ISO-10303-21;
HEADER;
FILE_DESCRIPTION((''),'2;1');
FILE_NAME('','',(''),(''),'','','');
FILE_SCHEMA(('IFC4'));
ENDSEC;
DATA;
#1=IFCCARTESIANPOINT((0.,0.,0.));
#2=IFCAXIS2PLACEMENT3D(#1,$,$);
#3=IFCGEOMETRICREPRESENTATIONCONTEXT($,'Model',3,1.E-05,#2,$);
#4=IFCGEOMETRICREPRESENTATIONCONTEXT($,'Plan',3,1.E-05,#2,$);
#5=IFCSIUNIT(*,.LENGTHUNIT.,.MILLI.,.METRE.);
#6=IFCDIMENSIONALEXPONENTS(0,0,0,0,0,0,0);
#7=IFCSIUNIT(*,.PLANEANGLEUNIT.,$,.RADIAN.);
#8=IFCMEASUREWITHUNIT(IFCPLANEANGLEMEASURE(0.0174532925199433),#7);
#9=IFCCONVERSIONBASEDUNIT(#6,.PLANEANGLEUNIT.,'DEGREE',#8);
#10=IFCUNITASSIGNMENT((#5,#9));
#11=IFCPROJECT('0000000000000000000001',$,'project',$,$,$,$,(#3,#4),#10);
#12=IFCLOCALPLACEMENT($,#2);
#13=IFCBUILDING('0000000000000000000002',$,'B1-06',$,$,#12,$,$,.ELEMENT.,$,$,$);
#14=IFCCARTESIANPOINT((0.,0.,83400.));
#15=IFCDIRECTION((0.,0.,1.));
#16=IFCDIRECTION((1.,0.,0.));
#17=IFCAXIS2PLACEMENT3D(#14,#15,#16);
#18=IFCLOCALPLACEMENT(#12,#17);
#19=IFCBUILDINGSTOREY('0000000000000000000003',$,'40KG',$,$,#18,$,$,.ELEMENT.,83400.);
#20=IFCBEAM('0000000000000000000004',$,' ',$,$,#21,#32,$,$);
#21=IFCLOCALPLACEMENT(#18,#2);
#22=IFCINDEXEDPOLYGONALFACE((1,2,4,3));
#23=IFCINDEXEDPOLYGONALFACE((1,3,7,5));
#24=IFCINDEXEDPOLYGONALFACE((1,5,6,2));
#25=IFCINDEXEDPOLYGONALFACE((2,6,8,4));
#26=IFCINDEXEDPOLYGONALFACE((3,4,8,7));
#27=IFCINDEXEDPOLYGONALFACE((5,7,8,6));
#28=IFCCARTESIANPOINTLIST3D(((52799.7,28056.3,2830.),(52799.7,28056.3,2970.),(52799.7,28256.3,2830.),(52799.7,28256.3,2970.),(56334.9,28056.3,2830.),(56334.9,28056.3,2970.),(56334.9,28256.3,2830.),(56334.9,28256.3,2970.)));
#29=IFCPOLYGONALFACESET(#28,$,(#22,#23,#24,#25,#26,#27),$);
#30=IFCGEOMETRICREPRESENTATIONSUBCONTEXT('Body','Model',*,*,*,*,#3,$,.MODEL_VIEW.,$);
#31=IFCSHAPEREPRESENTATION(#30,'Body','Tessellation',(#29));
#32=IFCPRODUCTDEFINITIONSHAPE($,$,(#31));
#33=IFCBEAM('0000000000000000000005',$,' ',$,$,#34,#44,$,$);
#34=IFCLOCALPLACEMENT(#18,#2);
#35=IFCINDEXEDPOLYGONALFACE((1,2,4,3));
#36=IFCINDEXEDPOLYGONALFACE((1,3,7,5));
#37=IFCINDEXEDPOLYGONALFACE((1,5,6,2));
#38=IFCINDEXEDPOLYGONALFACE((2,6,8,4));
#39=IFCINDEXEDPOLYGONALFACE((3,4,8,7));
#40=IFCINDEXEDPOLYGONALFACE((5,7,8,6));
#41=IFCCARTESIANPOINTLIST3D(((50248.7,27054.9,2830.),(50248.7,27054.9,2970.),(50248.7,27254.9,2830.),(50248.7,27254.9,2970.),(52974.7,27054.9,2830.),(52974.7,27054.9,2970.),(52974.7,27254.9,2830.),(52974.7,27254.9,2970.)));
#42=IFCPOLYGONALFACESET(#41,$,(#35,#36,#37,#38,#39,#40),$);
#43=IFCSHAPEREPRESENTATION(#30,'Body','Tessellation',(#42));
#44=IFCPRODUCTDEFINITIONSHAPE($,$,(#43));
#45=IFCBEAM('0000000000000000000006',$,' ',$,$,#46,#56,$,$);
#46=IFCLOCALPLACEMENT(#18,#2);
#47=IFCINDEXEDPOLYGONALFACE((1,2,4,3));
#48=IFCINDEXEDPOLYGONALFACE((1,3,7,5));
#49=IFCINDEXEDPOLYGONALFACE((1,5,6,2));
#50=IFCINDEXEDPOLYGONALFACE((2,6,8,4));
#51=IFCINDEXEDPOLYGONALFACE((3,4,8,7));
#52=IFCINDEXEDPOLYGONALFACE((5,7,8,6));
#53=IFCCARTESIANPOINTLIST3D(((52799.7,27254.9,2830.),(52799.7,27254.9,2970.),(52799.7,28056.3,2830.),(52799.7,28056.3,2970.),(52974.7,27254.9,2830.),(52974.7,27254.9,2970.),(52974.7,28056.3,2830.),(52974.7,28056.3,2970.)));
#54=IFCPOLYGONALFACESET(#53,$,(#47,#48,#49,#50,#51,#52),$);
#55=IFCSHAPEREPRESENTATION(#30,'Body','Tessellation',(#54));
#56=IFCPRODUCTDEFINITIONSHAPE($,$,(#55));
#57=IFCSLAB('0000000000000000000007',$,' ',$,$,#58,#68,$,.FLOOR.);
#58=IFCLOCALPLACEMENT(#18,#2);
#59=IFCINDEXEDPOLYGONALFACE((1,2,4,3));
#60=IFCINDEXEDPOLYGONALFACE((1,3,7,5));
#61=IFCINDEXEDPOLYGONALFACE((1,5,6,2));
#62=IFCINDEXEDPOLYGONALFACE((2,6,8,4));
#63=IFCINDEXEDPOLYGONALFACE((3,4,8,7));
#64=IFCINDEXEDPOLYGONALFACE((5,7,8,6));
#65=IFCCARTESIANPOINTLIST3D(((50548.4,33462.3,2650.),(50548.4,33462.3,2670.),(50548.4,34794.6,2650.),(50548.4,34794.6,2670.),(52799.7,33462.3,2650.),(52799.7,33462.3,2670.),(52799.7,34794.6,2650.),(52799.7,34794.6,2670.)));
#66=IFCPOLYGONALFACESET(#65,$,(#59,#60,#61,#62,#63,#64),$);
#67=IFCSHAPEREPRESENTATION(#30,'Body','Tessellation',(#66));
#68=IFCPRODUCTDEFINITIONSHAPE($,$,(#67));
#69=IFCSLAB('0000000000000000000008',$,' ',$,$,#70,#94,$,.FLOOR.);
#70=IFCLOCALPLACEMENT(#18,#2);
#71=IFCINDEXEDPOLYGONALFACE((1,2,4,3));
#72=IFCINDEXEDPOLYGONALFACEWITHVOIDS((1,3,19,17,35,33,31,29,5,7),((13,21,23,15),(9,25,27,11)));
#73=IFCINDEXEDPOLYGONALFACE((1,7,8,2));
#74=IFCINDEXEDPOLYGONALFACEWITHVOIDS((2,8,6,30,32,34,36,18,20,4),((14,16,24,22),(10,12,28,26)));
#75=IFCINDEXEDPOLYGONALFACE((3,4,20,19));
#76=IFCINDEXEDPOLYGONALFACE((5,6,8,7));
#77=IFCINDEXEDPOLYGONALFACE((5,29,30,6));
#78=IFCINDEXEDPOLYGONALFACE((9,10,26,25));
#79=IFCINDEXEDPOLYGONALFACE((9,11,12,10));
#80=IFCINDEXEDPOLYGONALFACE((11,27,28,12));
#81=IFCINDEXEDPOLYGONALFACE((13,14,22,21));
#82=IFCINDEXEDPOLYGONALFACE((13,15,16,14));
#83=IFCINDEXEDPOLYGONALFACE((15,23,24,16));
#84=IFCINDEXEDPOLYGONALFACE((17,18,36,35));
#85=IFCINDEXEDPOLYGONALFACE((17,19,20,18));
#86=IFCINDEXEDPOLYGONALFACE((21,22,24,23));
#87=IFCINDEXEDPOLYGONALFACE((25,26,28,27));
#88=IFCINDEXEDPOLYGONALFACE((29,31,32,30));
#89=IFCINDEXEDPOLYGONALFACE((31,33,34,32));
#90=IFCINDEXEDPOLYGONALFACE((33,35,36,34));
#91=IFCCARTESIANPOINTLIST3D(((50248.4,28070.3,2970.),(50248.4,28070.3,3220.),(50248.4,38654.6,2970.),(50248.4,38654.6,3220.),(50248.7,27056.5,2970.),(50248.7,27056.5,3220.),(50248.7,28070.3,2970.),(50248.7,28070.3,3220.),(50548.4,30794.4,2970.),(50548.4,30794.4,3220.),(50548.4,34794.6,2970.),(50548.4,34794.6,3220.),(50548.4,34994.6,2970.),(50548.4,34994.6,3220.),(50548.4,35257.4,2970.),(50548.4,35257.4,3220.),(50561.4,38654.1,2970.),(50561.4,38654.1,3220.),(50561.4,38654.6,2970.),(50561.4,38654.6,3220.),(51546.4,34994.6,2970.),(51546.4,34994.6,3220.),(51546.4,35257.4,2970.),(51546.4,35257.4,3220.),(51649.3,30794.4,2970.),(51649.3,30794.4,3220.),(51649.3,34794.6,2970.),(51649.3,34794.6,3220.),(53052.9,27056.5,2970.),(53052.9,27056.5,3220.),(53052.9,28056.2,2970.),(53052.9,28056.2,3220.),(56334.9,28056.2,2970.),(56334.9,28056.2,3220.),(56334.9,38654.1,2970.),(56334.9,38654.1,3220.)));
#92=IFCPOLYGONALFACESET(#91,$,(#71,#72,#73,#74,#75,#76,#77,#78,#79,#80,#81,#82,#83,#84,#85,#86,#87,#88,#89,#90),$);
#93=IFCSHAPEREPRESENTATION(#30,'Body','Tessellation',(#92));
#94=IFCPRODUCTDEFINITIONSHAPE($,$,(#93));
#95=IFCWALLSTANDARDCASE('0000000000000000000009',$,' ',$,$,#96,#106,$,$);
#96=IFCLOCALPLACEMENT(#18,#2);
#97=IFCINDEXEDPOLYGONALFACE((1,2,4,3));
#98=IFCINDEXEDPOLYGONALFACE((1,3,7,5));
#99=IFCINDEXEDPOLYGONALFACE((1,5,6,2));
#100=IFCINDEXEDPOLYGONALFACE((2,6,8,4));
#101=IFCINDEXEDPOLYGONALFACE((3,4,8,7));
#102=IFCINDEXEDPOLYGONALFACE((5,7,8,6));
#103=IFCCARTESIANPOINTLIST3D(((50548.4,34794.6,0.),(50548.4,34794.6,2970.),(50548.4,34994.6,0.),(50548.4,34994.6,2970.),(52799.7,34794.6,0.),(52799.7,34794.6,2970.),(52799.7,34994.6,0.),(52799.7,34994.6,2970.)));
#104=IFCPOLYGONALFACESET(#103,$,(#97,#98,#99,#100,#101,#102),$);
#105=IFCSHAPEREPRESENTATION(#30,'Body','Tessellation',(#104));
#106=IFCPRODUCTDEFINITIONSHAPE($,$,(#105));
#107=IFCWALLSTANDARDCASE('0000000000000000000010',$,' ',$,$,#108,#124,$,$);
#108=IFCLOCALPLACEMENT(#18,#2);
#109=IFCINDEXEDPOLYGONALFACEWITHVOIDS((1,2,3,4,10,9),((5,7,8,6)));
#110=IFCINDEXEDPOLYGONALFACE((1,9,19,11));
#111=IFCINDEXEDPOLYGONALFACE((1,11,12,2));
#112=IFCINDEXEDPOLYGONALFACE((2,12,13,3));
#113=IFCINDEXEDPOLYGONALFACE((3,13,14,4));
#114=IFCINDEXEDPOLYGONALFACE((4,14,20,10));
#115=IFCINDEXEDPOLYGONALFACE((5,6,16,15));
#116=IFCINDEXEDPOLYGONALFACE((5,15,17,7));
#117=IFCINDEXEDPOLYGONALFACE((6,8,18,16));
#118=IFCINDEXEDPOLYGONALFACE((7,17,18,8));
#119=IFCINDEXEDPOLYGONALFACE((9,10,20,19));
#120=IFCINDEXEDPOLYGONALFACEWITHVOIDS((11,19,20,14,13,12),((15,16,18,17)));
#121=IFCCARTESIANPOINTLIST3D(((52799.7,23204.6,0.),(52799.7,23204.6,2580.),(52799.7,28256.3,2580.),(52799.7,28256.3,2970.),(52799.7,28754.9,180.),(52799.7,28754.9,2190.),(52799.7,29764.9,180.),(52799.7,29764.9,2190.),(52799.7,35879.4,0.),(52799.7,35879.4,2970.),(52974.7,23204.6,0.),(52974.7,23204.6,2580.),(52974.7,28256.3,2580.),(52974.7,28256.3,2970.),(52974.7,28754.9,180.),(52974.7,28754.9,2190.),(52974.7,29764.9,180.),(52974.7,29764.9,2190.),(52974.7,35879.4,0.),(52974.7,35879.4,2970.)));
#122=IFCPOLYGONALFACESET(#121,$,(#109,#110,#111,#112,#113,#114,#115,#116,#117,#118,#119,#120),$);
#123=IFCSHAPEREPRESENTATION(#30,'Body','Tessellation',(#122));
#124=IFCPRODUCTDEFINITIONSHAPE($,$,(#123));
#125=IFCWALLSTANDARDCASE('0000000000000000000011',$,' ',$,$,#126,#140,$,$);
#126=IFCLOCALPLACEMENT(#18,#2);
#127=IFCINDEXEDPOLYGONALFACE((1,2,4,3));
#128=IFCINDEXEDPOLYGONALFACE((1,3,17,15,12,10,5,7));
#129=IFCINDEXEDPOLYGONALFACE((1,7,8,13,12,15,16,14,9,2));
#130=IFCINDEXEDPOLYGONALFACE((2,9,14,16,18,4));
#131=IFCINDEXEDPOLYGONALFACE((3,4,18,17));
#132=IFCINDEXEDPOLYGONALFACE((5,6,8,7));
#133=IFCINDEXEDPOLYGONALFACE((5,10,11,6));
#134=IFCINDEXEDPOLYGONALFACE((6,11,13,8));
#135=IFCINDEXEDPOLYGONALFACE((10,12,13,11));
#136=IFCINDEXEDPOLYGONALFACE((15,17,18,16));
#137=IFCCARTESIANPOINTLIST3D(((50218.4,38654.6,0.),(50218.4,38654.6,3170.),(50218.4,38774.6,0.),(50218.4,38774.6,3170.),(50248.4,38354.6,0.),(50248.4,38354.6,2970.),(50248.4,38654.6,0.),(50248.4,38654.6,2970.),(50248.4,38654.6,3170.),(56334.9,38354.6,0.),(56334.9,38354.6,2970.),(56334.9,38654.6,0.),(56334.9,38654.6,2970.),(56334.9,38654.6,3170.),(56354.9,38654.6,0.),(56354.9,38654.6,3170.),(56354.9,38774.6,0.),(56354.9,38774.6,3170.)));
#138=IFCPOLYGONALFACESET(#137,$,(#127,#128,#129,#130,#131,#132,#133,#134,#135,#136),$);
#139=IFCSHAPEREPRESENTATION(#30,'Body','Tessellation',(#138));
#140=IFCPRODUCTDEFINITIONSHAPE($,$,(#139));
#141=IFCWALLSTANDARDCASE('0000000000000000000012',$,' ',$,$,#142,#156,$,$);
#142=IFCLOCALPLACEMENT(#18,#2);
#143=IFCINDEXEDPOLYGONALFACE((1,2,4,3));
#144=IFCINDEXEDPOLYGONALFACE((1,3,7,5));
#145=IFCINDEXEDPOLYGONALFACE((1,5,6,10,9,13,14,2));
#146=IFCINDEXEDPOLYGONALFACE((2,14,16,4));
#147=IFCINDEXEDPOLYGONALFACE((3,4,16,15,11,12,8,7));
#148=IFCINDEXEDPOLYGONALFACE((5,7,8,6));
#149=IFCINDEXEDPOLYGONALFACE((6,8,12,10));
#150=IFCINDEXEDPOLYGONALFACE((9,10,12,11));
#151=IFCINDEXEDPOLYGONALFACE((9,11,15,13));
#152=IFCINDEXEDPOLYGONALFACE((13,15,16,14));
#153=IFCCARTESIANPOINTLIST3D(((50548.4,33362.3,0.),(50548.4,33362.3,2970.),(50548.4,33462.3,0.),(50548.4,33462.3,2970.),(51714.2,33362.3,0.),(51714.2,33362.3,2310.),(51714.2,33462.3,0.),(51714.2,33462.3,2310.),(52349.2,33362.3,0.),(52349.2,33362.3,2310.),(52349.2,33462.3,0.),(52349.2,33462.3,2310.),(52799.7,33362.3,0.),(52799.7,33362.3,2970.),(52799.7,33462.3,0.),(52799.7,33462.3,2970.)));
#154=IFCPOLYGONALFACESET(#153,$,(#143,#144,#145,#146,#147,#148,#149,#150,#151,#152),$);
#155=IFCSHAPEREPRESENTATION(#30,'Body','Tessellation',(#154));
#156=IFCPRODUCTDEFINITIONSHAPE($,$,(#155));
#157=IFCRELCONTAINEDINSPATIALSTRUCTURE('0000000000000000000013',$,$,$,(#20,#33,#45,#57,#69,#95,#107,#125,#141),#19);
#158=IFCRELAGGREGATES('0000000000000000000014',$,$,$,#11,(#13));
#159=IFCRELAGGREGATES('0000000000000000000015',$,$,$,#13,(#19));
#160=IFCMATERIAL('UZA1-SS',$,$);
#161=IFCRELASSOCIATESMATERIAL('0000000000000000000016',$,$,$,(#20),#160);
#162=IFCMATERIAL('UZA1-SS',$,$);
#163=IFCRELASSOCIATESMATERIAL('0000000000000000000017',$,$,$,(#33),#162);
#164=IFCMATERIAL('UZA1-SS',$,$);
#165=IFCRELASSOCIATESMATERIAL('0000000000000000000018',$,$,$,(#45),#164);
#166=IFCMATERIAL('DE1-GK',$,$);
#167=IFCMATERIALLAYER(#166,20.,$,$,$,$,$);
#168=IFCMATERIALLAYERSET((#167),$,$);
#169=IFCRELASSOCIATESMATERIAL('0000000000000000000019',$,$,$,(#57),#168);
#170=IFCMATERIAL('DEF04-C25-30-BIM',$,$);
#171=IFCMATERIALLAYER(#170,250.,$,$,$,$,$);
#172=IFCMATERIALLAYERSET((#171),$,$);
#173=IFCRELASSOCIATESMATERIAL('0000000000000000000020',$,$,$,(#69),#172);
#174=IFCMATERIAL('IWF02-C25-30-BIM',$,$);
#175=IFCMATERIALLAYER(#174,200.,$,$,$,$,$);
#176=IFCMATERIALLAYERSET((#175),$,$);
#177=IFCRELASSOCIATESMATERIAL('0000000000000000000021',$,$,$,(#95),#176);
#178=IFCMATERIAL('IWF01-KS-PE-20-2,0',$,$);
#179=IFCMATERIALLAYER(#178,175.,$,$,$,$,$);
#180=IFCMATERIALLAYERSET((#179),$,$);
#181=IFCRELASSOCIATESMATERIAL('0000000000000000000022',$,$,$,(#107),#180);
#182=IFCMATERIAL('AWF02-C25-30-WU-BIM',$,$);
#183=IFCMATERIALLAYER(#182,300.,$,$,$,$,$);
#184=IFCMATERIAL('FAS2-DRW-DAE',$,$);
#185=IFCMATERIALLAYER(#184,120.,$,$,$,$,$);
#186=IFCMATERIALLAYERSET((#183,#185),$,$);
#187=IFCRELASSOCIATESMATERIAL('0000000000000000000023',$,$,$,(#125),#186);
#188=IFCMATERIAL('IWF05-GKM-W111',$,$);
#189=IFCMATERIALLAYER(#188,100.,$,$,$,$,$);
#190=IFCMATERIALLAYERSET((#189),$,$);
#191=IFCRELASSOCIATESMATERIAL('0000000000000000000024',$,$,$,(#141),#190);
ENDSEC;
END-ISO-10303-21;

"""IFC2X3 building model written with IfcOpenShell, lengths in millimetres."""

from ifc_helpers import new_model, entity, si_unit, converted_unit, frame, frame_2d, origin, origin_with_axes, place, context, subcontext, project, spatial, polyline, rectangle, outline, extrude, clip, bounded_halfspace, material, layer, layer_set, layer_usage, element, save


model = new_model("IFC2X3")

# Units and contexts
model_context = context("Model", 3, precision=1e-05, world=origin())
plan_context = context("Plan", 3, precision=1e-05, world=origin())
body_context = subcontext(model_context, "Body", "Model", "MODEL_VIEW")
ifc_project = project(units=[si_unit("LENGTHUNIT", "METRE", prefix="MILLI"), converted_unit("PLANEANGLEUNIT", "DEGREE", entity("IfcPlaneAngleMeasure", 0.0174532925199433), si_unit("PLANEANGLEUNIT", "RADIAN"), dimensions=[0, 0, 0, 0, 0, 0, 0])], contexts=[model_context, plan_context])

# Building, storey
building_placement = place(None, origin())
building = spatial("IfcBuilding", under=ifc_project, at=building_placement, Name="B1-06", CompositionType="ELEMENT")
storey_placement = place(building_placement, frame((0.0, 0.0, 83400.0), z_axis=(0.0, 0.0, 1.0), x_axis=(1.0, 0.0, 0.0)))
storey = spatial("IfcBuildingStorey", under=building, at=storey_placement, Name="40KG", CompositionType="ELEMENT", Elevation=83400.0)

# Beams
ifc_material_1 = material(Name="UZA1-SS")
beam_1_placement = place(storey_placement, frame((56334.9, 28256.3, 2830.0), z_axis=(0.0, 0.0, 1.0), x_axis=(-1.0, 0.0, 0.0)))
element("IfcBeam", 1, at=beam_1_placement, inside=storey, material=ifc_material_1, Name=" ", context=body_context, shape_type="SweptSolid", body=[
    extrude(rectangle(XDim=140.0, YDim=200.0, at=frame_2d((70.0, -100.0), x_axis=(1.0, 0.0))), frame((0.0, 0.0, 0.0), z_axis=(1.0, 0.0, 0.0), x_axis=(0.0, 0.0, 1.0)), (0.0, 0.0, 1.0), 3535.2),
])
ifc_material_2 = material(Name="UZA1-SS")
beam_2_placement = place(storey_placement, frame((52974.7, 27254.9, 2830.0), z_axis=(0.0, 0.0, 1.0), x_axis=(-1.0, 0.0, 0.0)))
element("IfcBeam", 2, at=beam_2_placement, inside=storey, material=ifc_material_2, Name=" ", context=body_context, shape_type="SweptSolid", body=[
    extrude(rectangle(XDim=140.0, YDim=200.0, at=frame_2d((70.0, -100.0), x_axis=(1.0, 0.0))), frame((0.0, 0.0, 0.0), z_axis=(1.0, 0.0, 0.0), x_axis=(0.0, 0.0, 1.0)), (0.0, 0.0, 1.0), 2726.0),
])
ifc_material_3 = material(Name="UZA1-SS")
beam_3_placement = place(storey_placement, frame((52799.7, 28056.3, 2830.0), z_axis=(0.0, 0.0, 1.0), x_axis=(0.0, -1.0, 0.0)))
element("IfcBeam", 3, at=beam_3_placement, inside=storey, material=ifc_material_3, Name=" ", context=body_context, shape_type="SweptSolid", body=[
    extrude(rectangle(XDim=140.0, YDim=175.0, at=frame_2d((70.0, -87.5), x_axis=(1.0, 0.0))), frame((0.0, 0.0, 0.0), z_axis=(1.0, 0.0, 0.0), x_axis=(0.0, 0.0, 1.0)), (0.0, 0.0, 1.0), 801.4),
])

# Slab
ifc_material_4 = material(Name="DE1-GK")
ifc_layer_1 = layer(ifc_material_4, 20.0)
ifc_layer_set_1 = layer_set([ifc_layer_1])
ifc_layer_usage_1 = layer_usage(ifc_layer_set_1, "AXIS3", "POSITIVE", 0.0)
slab_1_placement = place(storey_placement, frame((50548.4, 34794.6, 2650.0), z_axis=(0.0, 0.0, 1.0), x_axis=(1.0, 0.0, 0.0)))
element("IfcSlab", 4, at=slab_1_placement, inside=storey, material=ifc_layer_usage_1, Name=" ", PredefinedType="FLOOR", context=body_context, shape_type="SweptSolid", body=[
    extrude(rectangle(XDim=1332.2, YDim=2251.3, at=frame_2d((1125.7, -666.1), x_axis=(0.0, -1.0))), origin_with_axes(), (0.0, 0.0, 1.0), 20.0),
])

# Slab, openings
ifc_material_5 = material(Name="DEF04-C25-30-BIM")
ifc_layer_2 = layer(ifc_material_5, 250.0)
ifc_layer_set_2 = layer_set([ifc_layer_2])
ifc_layer_usage_2 = layer_usage(ifc_layer_set_2, "AXIS3", "POSITIVE", 0.0)
slab_2_placement = place(storey_placement, frame((50248.4, 27056.5, 2970.0), z_axis=(0.0, 0.0, 1.0), x_axis=(1.0, 0.0, 0.0)))
slab_2 = element("IfcSlab", 5, at=slab_2_placement, inside=storey, material=ifc_layer_usage_2, Name=" ", PredefinedType="FLOOR", context=body_context, shape_type="SweptSolid", body=[
    extrude(outline(polyline([(0.0, 11598.1), (0.0, 1013.8), (0.3, 1013.8), (0.3, 198.4), (0.3, 0.0), (2804.6, 0.0), (2804.6, 999.8), (6086.5, 999.8), (6086.5, 999.8), (6086.5, 11597.7), (313.1, 11597.7), (313.1, 11598.1), (0.0, 11598.1)])), origin_with_axes(), (0.0, 0.0, 1.0), 250.0),
])
opening_1_placement = place(slab_2_placement, frame((300.0, 3737.9, 0.0), z_axis=(0.0, 0.0, 1.0), x_axis=(1.0, 0.0, 0.0)))
element("IfcOpeningElement", 6, at=opening_1_placement, cuts=slab_2, ObjectType="Opening", context=body_context, shape_type="SweptSolid", body=[
    extrude(rectangle(XDim=1100.9, YDim=4000.2, at=frame_2d((550.5, 2000.1), x_axis=(1.0, 0.0))), origin_with_axes(), (0.0, 0.0, 1.0), 250.0),
])
opening_2_placement = place(slab_2_placement, frame((300.0, 8200.9, 0.0), z_axis=(0.0, 0.0, 1.0), x_axis=(1.0, 0.0, 0.0)))
element("IfcOpeningElement", 7, at=opening_2_placement, cuts=slab_2, ObjectType="Opening", context=body_context, shape_type="SweptSolid", body=[
    extrude(rectangle(XDim=262.8, YDim=998.0, at=frame_2d((499.0, -131.4), x_axis=(0.0, -1.0))), origin_with_axes(), (0.0, 0.0, 1.0), 250.0),
])

# Wall
ifc_material_6 = material(Name="IWF02-C25-30-BIM")
ifc_layer_3 = layer(ifc_material_6, 200.0)
ifc_layer_set_3 = layer_set([ifc_layer_3])
ifc_layer_usage_3 = layer_usage(ifc_layer_set_3, "AXIS2", "POSITIVE", 0.0)
wall_1_placement = place(storey_placement, frame((52799.7, 34994.6, 0.0), z_axis=(0.0, 0.0, 1.0), x_axis=(-1.0, 0.0, 0.0)))
element("IfcWallStandardCase", 8, at=wall_1_placement, inside=storey, material=ifc_layer_usage_3, Name=" ", context=body_context, shape_type="SweptSolid", body=[
    extrude(rectangle(XDim=2251.3, YDim=200.0, at=frame_2d((1125.7, 100.0), x_axis=(1.0, 0.0))), origin_with_axes(), (0.0, 0.0, 1.0), 2970.0),
])

# Wall, opening
ifc_material_7 = material(Name="IWF01-KS-PE-20-2,0")
ifc_layer_4 = layer(ifc_material_7, 175.0)
ifc_layer_set_4 = layer_set([ifc_layer_4])
ifc_layer_usage_4 = layer_usage(ifc_layer_set_4, "AXIS2", "POSITIVE", 0.0)
wall_2_placement = place(storey_placement, frame((52799.7, 35879.4, 0.0), z_axis=(0.0, 0.0, 1.0), x_axis=(0.0, -1.0, 0.0)))
wall_2 = element("IfcWallStandardCase", 9, at=wall_2_placement, inside=storey, material=ifc_layer_usage_4, Name=" ", context=body_context, shape_type="Clipping", body=[
    clip(clip(extrude(rectangle(XDim=12674.8, YDim=175.0, at=frame_2d((6337.4, 87.5), x_axis=(1.0, 0.0))), origin_with_axes(), (0.0, 0.0, 1.0), 2970.0), bounded_halfspace(frame((7623.1, 0.0, 2580.0), z_axis=(0.0, 0.0, -1.0), x_axis=(1.0, 0.0, 0.0)), True, origin(), polyline([(7623.1, 0.0), (12674.8, 0.0), (12674.8, 175.0), (7623.1, 175.0), (7623.1, 0.0)]))), bounded_halfspace(frame((7623.1, 0.0, 2970.0), z_axis=(0.0, 0.0, -1.0), x_axis=(0.0, 1.0, 0.0)), True, origin(), polyline([(7623.1, 0.0), (7623.1, 175.0), (0.0, 175.0), (0.0, 0.0), (7623.1, 0.0)]))),
])
opening_3_placement = place(wall_2_placement, frame((6114.5, 0.0, 180.0), z_axis=(0.0, 1.0, 0.0), x_axis=(0.0, 0.0, 1.0)))
element("IfcOpeningElement", 10, at=opening_3_placement, cuts=wall_2, ObjectType="Opening", context=body_context, shape_type="SweptSolid", body=[
    extrude(rectangle(XDim=2010.0, YDim=1010.0, at=frame_2d((1005.0, 505.0), x_axis=(1.0, 0.0))), origin_with_axes(), (0.0, 0.0, 1.0), 175.0),
])

# Wall
ifc_material_8 = material(Name="AWF02-C25-30-WU-BIM")
ifc_layer_5 = layer(ifc_material_8, 300.0)
ifc_material_9 = material(Name="FAS2-DRW-DAE")
ifc_layer_6 = layer(ifc_material_9, 120.0)
ifc_layer_set_5 = layer_set([ifc_layer_5, ifc_layer_6])
ifc_layer_usage_5 = layer_usage(ifc_layer_set_5, "AXIS2", "POSITIVE", 0.0)
wall_3_placement = place(storey_placement, frame((50248.4, 38354.6, 0.0), z_axis=(0.0, 0.0, 1.0), x_axis=(1.0, 0.0, 0.0)))
element("IfcWallStandardCase", 11, at=wall_3_placement, inside=storey, material=ifc_layer_usage_5, Name=" ", context=body_context, shape_type="Clipping", body=[
    clip(clip(extrude(outline(polyline([(0.0, 0.0), (6086.5, 0.0), (6086.5, 300.0), (6106.5, 300.0), (6106.5, 420.0), (-30.0, 420.0), (-30.0, 300.0), (0.0, 300.0), (0.0, 0.0)])), origin_with_axes(), (0.0, 0.0, 1.0), 3170.0), bounded_halfspace(frame((0.0, 0.0, 2970.0), z_axis=(0.0, 0.0, -1.0), x_axis=(1.0, 0.0, 0.0)), True, origin(), polyline([(0.0, 0.0), (6086.5, 0.0), (6086.5, 300.0), (0.0, 300.0), (0.0, 0.0)]))), bounded_halfspace(frame((-30.0, 300.0, 3170.0), z_axis=(0.0, 0.0, -1.0), x_axis=(1.0, 0.0, 0.0)), True, origin(), polyline([(-30.0, 300.0), (6106.5, 300.0), (6106.5, 420.0), (-30.0, 420.0), (-30.0, 300.0)]))),
])

# Wall, opening
ifc_material_10 = material(Name="IWF05-GKM-W111")
ifc_layer_7 = layer(ifc_material_10, 100.0)
ifc_layer_set_6 = layer_set([ifc_layer_7])
ifc_layer_usage_6 = layer_usage(ifc_layer_set_6, "AXIS2", "POSITIVE", 0.0)
wall_4_placement = place(storey_placement, frame((50548.4, 33362.3, 0.0), z_axis=(0.0, 0.0, 1.0), x_axis=(1.0, 0.0, 0.0)))
wall_4 = element("IfcWallStandardCase", 12, at=wall_4_placement, inside=storey, material=ifc_layer_usage_6, Name=" ", context=body_context, shape_type="SweptSolid", body=[
    extrude(rectangle(XDim=2251.3, YDim=100.0, at=frame_2d((1125.7, 50.0), x_axis=(1.0, 0.0))), origin_with_axes(), (0.0, 0.0, 1.0), 2970.0),
])
opening_4_placement = place(wall_4_placement, frame((1165.8, 0.0, 0.0), z_axis=(0.0, 1.0, 0.0), x_axis=(0.0, 0.0, 1.0)))
element("IfcOpeningElement", 13, at=opening_4_placement, cuts=wall_4, ObjectType="Opening", context=body_context, shape_type="SweptSolid", body=[
    extrude(rectangle(XDim=2310.0, YDim=635.0, at=frame_2d((1155.0, 317.5), x_axis=(1.0, 0.0))), origin_with_axes(), (0.0, 0.0, 1.0), 100.0),
])

save(model, "model.ifc")
